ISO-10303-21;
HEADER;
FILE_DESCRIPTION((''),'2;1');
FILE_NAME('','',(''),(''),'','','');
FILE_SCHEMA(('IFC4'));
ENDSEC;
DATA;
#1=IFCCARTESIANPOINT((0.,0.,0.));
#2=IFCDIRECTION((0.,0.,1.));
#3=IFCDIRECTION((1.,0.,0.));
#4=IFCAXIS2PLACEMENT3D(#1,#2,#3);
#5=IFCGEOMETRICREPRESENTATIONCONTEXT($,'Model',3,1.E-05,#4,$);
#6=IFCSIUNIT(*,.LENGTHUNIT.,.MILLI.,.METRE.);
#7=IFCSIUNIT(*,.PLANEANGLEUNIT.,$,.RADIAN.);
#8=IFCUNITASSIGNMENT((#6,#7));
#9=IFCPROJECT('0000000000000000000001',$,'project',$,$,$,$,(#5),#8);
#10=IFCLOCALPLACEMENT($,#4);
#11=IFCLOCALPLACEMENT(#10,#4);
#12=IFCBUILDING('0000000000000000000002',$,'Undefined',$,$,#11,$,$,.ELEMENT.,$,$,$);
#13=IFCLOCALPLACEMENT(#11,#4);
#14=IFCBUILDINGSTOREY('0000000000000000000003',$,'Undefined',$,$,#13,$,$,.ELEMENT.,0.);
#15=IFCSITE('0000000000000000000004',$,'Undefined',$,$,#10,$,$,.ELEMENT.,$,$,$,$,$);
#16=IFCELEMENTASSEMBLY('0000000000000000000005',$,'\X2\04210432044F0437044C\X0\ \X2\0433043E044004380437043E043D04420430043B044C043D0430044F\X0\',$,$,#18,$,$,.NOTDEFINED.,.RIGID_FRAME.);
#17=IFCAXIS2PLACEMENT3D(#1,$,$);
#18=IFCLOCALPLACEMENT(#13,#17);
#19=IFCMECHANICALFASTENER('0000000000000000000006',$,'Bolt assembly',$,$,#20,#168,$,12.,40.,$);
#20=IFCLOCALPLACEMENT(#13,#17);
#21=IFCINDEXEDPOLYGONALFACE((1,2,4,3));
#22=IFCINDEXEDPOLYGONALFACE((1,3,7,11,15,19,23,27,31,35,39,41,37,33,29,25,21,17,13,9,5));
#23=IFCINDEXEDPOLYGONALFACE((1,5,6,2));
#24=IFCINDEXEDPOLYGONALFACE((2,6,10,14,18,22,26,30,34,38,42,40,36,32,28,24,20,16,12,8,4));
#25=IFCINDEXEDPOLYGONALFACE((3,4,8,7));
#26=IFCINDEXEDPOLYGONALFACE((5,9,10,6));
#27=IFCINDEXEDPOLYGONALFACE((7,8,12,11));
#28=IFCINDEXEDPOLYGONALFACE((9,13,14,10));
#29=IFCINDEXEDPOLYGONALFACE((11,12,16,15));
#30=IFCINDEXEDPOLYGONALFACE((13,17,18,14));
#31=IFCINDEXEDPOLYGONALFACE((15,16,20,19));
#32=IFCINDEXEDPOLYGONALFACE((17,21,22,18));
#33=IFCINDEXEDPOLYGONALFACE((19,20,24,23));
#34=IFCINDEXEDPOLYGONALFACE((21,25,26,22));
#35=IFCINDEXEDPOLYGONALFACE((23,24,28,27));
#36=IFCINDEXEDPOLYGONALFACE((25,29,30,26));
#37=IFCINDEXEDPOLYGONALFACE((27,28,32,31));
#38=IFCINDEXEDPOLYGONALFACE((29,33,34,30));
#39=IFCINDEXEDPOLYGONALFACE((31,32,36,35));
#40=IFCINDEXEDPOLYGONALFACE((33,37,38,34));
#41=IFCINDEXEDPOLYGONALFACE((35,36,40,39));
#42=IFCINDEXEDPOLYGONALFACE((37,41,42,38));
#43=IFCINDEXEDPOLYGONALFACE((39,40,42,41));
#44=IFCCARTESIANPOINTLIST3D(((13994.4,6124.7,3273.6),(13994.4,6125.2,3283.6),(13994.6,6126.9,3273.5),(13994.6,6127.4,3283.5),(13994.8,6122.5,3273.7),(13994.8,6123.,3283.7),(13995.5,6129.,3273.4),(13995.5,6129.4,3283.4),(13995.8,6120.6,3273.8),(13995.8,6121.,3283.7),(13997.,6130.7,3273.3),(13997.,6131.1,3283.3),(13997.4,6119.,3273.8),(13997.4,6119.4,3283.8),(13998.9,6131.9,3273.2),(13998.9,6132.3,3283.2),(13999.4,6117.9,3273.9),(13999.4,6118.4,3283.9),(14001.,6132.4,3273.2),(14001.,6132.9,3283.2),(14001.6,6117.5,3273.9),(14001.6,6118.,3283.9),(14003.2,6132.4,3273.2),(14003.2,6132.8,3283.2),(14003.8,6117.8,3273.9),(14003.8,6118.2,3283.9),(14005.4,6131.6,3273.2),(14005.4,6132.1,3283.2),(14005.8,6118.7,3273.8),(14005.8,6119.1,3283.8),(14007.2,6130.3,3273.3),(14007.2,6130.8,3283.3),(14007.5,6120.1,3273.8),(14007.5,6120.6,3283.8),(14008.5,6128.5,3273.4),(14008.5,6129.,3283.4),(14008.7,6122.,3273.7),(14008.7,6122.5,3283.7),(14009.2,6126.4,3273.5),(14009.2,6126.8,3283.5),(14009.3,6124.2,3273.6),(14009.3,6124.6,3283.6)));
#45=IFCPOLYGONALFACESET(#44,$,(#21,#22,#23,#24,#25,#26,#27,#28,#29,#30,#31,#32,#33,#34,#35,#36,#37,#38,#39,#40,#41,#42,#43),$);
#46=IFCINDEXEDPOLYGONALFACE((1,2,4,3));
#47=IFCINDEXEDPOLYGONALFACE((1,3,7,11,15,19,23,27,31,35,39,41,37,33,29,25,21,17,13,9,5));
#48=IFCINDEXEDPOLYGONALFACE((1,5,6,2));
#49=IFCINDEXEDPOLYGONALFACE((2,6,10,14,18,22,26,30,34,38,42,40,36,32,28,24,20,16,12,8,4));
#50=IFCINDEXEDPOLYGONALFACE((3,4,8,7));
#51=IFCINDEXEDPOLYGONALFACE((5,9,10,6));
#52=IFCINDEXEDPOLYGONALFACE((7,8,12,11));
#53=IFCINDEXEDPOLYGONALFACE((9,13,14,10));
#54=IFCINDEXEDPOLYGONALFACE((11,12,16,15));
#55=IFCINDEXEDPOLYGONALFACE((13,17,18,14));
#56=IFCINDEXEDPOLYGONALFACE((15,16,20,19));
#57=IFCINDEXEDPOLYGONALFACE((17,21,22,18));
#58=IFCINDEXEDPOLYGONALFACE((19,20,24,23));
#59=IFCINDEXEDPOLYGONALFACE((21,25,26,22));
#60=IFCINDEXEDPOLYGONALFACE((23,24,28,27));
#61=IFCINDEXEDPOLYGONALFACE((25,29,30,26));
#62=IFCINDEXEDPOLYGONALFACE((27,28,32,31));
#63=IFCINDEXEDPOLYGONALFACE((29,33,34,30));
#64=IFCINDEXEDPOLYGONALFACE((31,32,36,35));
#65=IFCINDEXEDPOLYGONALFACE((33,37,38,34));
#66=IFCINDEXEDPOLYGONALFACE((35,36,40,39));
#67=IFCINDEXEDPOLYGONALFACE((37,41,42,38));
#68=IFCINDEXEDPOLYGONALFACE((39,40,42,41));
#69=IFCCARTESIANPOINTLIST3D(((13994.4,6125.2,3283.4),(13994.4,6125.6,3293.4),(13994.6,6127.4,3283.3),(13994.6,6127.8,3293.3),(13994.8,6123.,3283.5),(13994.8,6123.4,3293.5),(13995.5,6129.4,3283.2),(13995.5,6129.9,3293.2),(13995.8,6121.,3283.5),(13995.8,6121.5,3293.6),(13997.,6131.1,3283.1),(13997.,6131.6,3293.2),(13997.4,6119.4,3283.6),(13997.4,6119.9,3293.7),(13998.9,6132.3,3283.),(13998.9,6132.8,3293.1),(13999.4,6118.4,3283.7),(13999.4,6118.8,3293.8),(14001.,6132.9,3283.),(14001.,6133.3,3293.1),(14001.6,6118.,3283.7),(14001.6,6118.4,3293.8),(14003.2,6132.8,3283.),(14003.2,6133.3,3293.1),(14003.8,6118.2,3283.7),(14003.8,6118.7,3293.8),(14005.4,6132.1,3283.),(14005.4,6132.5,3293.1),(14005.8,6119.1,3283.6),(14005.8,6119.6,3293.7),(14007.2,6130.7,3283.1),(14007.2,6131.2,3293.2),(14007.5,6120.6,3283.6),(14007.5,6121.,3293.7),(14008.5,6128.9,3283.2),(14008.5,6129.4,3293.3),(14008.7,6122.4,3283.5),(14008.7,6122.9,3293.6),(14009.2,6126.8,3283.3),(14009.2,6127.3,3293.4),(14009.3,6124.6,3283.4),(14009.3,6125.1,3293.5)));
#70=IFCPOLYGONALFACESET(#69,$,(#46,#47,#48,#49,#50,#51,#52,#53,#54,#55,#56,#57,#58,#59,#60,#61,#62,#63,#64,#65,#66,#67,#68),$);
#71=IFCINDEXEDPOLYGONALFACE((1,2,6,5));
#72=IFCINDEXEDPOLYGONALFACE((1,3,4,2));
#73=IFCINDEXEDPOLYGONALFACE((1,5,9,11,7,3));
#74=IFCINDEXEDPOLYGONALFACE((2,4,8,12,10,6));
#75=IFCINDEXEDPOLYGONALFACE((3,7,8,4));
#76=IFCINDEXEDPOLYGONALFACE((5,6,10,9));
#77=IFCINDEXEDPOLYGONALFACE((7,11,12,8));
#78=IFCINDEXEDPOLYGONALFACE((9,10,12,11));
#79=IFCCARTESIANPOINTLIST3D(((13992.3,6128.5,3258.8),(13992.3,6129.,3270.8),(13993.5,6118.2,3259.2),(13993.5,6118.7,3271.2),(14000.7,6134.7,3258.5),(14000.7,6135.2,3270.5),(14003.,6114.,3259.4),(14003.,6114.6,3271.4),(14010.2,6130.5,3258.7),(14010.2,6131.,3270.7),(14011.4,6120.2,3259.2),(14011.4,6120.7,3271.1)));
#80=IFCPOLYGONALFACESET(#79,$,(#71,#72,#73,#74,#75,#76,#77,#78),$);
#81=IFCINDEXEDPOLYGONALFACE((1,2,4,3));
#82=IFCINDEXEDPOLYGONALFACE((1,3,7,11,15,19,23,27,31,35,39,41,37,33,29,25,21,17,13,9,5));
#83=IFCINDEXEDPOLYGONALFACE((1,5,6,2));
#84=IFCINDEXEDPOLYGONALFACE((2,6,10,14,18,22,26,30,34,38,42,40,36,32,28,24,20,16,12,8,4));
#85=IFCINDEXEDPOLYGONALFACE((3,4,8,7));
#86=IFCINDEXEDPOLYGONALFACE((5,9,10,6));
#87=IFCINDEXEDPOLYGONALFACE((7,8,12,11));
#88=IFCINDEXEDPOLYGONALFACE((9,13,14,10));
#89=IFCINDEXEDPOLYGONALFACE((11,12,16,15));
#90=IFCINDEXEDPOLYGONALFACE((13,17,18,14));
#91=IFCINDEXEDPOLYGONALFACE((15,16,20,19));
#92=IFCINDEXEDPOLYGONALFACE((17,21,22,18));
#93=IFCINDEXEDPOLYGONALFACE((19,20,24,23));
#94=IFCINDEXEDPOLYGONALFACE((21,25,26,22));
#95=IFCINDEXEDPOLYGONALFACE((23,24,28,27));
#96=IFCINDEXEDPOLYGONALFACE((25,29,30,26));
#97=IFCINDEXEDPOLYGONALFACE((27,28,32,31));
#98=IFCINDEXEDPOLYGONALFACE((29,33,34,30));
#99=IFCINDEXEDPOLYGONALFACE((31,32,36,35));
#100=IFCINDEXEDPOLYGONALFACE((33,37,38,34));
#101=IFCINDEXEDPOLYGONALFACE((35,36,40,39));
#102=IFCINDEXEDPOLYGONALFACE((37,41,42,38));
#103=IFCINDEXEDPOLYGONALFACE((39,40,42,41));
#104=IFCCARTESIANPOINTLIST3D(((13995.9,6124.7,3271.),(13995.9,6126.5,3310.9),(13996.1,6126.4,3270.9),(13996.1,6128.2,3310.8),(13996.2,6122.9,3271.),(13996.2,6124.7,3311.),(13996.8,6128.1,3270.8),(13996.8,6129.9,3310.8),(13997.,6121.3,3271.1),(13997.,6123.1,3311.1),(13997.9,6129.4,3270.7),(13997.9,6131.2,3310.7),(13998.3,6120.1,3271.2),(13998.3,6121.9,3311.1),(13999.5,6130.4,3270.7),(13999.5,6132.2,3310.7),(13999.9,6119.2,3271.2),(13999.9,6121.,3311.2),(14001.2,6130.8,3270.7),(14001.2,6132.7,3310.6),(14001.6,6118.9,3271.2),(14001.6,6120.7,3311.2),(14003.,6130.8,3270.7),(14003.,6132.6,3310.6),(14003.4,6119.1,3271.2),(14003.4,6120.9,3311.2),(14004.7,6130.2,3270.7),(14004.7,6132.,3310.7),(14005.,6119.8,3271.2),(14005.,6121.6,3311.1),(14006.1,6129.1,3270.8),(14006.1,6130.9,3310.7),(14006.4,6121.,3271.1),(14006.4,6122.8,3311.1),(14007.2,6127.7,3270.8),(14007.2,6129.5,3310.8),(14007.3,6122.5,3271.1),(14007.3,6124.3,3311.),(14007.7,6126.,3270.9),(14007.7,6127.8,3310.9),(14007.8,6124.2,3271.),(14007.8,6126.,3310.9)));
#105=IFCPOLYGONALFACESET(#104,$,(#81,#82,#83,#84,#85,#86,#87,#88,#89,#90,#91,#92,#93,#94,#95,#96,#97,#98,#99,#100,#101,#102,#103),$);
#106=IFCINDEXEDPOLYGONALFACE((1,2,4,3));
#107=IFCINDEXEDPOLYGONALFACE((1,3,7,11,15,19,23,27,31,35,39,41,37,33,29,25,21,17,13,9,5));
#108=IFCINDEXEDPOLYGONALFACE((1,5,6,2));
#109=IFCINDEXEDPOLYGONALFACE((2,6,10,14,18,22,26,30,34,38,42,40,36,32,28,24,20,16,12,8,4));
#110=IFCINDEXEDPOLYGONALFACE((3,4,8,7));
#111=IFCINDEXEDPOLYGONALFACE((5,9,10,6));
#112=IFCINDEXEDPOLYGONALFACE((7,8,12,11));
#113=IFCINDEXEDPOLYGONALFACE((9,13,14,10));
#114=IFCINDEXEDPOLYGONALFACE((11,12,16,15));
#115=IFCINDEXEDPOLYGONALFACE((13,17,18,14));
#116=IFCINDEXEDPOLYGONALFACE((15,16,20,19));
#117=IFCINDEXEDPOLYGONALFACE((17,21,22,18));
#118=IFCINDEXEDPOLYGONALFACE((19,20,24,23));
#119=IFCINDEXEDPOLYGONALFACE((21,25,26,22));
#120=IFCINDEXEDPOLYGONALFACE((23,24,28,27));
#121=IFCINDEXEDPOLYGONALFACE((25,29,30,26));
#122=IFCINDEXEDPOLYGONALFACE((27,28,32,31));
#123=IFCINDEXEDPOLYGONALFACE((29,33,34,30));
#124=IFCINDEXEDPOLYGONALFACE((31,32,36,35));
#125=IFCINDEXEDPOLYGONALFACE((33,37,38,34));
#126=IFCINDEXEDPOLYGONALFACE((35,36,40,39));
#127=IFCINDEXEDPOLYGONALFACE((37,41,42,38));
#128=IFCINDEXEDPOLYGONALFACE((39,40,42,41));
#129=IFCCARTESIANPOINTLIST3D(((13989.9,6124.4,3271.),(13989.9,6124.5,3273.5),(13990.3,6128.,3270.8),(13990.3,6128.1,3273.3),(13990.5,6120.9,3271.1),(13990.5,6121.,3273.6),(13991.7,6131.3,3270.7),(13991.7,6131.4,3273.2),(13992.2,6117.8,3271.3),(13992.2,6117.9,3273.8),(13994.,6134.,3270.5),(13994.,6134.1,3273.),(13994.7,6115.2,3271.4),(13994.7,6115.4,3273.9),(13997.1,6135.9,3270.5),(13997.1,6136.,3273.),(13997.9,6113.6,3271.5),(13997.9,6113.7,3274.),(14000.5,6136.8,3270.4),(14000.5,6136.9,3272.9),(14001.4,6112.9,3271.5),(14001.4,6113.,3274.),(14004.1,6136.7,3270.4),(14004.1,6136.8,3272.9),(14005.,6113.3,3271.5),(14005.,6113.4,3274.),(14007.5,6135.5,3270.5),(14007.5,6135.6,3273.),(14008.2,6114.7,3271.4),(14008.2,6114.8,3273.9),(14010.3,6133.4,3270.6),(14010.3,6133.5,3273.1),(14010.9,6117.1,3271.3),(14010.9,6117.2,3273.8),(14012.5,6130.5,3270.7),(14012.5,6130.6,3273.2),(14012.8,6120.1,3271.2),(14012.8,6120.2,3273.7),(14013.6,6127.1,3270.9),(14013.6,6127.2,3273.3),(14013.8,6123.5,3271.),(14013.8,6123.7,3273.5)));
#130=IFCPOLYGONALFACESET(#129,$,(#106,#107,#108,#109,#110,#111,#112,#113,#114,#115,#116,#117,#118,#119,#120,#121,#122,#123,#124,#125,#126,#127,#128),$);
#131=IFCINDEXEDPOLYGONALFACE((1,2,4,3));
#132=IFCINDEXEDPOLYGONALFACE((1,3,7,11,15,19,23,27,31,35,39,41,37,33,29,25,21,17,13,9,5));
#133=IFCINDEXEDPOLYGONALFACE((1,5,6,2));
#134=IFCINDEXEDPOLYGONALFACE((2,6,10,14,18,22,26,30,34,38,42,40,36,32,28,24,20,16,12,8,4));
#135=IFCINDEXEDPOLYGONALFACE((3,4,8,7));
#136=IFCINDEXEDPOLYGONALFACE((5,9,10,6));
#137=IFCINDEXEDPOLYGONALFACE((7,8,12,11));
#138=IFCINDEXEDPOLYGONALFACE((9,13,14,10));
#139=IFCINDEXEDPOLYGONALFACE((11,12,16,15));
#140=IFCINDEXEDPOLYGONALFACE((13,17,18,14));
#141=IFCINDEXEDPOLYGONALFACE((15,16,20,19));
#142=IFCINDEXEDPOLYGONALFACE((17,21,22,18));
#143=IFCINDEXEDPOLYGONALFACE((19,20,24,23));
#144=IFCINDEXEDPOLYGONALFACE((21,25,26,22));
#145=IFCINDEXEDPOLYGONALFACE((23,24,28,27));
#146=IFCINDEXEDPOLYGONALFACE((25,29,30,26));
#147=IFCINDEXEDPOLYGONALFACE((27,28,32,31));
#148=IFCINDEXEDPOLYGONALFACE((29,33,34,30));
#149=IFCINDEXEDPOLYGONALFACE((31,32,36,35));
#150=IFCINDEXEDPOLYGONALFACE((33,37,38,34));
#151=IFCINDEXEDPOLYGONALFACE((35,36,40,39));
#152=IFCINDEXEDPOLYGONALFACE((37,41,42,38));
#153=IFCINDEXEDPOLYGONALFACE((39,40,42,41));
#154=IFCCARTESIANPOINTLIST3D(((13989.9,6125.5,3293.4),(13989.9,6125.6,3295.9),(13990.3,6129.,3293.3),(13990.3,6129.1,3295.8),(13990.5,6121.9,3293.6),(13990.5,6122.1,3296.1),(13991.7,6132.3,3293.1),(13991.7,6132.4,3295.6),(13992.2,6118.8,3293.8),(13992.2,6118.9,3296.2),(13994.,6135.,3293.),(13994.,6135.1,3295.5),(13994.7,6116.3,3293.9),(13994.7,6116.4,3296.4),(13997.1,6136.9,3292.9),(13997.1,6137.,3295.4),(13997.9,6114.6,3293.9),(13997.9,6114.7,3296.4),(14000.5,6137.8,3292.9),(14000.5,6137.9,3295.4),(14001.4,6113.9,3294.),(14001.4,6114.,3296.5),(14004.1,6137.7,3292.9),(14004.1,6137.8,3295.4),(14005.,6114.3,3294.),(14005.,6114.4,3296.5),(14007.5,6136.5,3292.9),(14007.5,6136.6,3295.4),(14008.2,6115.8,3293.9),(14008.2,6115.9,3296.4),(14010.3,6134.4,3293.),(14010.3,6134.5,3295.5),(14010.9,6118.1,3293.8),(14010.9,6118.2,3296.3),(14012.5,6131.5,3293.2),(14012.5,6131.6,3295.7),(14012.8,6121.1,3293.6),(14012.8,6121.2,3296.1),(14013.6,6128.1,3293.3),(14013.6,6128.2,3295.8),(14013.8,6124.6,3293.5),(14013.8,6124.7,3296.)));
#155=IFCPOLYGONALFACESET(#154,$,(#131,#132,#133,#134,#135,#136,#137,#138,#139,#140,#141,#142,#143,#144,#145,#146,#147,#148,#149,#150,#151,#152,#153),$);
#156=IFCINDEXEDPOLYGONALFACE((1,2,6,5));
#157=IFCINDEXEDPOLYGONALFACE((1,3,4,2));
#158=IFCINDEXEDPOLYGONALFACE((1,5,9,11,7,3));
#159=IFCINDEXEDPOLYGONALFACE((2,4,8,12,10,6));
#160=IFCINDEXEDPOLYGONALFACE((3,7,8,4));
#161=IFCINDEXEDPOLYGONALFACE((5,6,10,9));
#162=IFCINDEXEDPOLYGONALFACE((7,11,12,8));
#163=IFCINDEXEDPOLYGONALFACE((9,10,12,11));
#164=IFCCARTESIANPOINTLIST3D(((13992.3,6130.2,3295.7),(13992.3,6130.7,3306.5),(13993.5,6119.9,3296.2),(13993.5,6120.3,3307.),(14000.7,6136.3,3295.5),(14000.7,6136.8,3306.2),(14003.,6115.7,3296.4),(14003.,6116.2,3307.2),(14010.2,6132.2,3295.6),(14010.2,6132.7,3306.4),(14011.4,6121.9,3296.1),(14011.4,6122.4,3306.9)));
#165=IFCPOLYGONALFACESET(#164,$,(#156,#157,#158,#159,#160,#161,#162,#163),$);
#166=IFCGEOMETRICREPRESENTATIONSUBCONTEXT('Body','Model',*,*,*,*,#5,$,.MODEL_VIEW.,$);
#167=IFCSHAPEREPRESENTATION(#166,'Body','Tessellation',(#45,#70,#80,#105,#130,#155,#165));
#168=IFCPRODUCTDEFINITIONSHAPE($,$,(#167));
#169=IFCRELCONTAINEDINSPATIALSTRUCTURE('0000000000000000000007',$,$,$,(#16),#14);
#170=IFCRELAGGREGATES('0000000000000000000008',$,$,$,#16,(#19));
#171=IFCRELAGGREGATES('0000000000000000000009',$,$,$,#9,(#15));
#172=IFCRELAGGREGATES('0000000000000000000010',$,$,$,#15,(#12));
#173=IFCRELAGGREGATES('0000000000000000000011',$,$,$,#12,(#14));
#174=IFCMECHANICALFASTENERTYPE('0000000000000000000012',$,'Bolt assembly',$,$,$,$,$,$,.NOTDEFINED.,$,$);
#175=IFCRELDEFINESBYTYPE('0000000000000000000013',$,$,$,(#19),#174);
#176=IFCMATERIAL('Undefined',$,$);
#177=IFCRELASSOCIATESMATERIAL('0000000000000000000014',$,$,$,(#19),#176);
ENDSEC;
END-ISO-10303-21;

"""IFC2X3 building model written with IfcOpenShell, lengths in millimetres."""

from ifc_helpers import new_model, si_unit, frame, origin_with_axes, origin_2d_with_axis, place, context, subcontext, project, spatial, polyline, circle, outline, extrude, source, transform, mapped, material, type_object, element, aggregate, save


model = new_model("IFC2X3")

# Units and contexts
model_context = context("Model", 3, precision=1e-05, world=origin_with_axes())
body_context = subcontext(model_context, "Body", "Model", "MODEL_VIEW")
ifc_project = project(units=[si_unit("LENGTHUNIT", "METRE", prefix="MILLI"), si_unit("PLANEANGLEUNIT", "RADIAN")], contexts=[model_context])

# Site, building, storey
site_placement = place(None, origin_with_axes())
site = spatial("IfcSite", under=ifc_project, at=site_placement, Name="Undefined", CompositionType="ELEMENT")
building_placement = place(site_placement, origin_with_axes())
building = spatial("IfcBuilding", under=site, at=building_placement, Name="Undefined", CompositionType="ELEMENT")
storey_placement = place(building_placement, origin_with_axes())
storey = spatial("IfcBuildingStorey", under=building, at=storey_placement, Name="Undefined", CompositionType="ELEMENT", Elevation=0.0)

# Element assembly
assembly_1_placement = place(storey_placement, origin_with_axes())
assembly_1 = element("IfcElementAssembly", 1, at=assembly_1_placement, inside=storey, Name="Связь горизонтальная", AssemblyPlace="NOTDEFINED", PredefinedType="RIGID_FRAME")

# Mechanical fastener
ifc_material_1 = material(Name="Undefined")
mechanical_fastener_type = type_object("IfcMechanicalFastenerType", Name="Bolt assembly")
shared_shape_1 = source(origin_with_axes(), body_context, "Body", "SweptSolid", [
    extrude(circle(Radius=7.5, at=origin_2d_with_axis()), frame((0.0, 0.1, 0.0), z_axis=(0.0, 1.0, 0.0), x_axis=(1.0, 0.0, 0.0)), (0.0, 0.0, 1.0), 10.0),
    extrude(circle(Radius=7.5, at=origin_2d_with_axis()), frame((0.0, 9.9, 0.0), z_axis=(0.0, 1.0, 0.0), x_axis=(1.0, 0.0, 0.0)), (0.0, 0.0, 1.0), 10.1),
    extrude(outline(polyline([(10.4, 0.0), (5.2, 9.0), (-5.2, 9.0), (-10.4, 0.0), (-5.2, -9.0), (5.2, -9.0), (10.4, 0.0)])), frame((0.0, -14.5, 0.0), z_axis=(0.0, 1.0, 0.0), x_axis=(1.0, 0.0, 0.0)), (0.0, 0.0, 1.0), 12.0),
    extrude(circle(Radius=6.0, at=origin_2d_with_axis()), frame((0.0, -2.5, 0.0), z_axis=(0.0, 1.0, 0.0), x_axis=(1.0, 0.0, 0.0)), (0.0, 0.0, 1.0), 40.0),
    extrude(circle(Radius=12.0, at=origin_2d_with_axis()), frame((0.0, -2.5, 0.0), z_axis=(0.0, 1.0, 0.0), x_axis=(1.0, 0.0, 0.0)), (0.0, 0.0, 1.0), 2.5),
    extrude(circle(Radius=12.0, at=origin_2d_with_axis()), frame((0.0, 20.0, 0.0), z_axis=(0.0, 1.0, 0.0), x_axis=(1.0, 0.0, 0.0)), (0.0, 0.0, 1.0), 2.5),
    extrude(outline(polyline([(10.4, 0.0), (5.2, 9.0), (-5.2, 9.0), (-10.4, 0.0), (-5.2, -9.0), (5.2, -9.0), (10.4, 0.0)])), frame((0.0, 22.5, 0.0), z_axis=(0.0, 1.0, 0.0), x_axis=(1.0, 0.0, 0.0)), (0.0, 0.0, 1.0), 10.8),
])
mechanical_fastener_1_placement = place(assembly_1_placement, frame((14001.9, 6125.0, 3273.4), z_axis=(-0.593795, 0.803786, -0.036536), x_axis=(-0.804616, -0.593183, 0.026963)))
mechanical_fastener_1 = element("IfcMechanicalFastener", 2, at=mechanical_fastener_1_placement, type_object=mechanical_fastener_type, material=ifc_material_1, Name="Bolt assembly", NominalDiameter=12.0, NominalLength=40.0, context=body_context, shape_type="MappedRepresentation", body=[
    mapped(shared_shape_1, transform((0.0, 0.0, 0.0))),
])
aggregate(assembly_1, [mechanical_fastener_1])

save(model, "model.ifc")
